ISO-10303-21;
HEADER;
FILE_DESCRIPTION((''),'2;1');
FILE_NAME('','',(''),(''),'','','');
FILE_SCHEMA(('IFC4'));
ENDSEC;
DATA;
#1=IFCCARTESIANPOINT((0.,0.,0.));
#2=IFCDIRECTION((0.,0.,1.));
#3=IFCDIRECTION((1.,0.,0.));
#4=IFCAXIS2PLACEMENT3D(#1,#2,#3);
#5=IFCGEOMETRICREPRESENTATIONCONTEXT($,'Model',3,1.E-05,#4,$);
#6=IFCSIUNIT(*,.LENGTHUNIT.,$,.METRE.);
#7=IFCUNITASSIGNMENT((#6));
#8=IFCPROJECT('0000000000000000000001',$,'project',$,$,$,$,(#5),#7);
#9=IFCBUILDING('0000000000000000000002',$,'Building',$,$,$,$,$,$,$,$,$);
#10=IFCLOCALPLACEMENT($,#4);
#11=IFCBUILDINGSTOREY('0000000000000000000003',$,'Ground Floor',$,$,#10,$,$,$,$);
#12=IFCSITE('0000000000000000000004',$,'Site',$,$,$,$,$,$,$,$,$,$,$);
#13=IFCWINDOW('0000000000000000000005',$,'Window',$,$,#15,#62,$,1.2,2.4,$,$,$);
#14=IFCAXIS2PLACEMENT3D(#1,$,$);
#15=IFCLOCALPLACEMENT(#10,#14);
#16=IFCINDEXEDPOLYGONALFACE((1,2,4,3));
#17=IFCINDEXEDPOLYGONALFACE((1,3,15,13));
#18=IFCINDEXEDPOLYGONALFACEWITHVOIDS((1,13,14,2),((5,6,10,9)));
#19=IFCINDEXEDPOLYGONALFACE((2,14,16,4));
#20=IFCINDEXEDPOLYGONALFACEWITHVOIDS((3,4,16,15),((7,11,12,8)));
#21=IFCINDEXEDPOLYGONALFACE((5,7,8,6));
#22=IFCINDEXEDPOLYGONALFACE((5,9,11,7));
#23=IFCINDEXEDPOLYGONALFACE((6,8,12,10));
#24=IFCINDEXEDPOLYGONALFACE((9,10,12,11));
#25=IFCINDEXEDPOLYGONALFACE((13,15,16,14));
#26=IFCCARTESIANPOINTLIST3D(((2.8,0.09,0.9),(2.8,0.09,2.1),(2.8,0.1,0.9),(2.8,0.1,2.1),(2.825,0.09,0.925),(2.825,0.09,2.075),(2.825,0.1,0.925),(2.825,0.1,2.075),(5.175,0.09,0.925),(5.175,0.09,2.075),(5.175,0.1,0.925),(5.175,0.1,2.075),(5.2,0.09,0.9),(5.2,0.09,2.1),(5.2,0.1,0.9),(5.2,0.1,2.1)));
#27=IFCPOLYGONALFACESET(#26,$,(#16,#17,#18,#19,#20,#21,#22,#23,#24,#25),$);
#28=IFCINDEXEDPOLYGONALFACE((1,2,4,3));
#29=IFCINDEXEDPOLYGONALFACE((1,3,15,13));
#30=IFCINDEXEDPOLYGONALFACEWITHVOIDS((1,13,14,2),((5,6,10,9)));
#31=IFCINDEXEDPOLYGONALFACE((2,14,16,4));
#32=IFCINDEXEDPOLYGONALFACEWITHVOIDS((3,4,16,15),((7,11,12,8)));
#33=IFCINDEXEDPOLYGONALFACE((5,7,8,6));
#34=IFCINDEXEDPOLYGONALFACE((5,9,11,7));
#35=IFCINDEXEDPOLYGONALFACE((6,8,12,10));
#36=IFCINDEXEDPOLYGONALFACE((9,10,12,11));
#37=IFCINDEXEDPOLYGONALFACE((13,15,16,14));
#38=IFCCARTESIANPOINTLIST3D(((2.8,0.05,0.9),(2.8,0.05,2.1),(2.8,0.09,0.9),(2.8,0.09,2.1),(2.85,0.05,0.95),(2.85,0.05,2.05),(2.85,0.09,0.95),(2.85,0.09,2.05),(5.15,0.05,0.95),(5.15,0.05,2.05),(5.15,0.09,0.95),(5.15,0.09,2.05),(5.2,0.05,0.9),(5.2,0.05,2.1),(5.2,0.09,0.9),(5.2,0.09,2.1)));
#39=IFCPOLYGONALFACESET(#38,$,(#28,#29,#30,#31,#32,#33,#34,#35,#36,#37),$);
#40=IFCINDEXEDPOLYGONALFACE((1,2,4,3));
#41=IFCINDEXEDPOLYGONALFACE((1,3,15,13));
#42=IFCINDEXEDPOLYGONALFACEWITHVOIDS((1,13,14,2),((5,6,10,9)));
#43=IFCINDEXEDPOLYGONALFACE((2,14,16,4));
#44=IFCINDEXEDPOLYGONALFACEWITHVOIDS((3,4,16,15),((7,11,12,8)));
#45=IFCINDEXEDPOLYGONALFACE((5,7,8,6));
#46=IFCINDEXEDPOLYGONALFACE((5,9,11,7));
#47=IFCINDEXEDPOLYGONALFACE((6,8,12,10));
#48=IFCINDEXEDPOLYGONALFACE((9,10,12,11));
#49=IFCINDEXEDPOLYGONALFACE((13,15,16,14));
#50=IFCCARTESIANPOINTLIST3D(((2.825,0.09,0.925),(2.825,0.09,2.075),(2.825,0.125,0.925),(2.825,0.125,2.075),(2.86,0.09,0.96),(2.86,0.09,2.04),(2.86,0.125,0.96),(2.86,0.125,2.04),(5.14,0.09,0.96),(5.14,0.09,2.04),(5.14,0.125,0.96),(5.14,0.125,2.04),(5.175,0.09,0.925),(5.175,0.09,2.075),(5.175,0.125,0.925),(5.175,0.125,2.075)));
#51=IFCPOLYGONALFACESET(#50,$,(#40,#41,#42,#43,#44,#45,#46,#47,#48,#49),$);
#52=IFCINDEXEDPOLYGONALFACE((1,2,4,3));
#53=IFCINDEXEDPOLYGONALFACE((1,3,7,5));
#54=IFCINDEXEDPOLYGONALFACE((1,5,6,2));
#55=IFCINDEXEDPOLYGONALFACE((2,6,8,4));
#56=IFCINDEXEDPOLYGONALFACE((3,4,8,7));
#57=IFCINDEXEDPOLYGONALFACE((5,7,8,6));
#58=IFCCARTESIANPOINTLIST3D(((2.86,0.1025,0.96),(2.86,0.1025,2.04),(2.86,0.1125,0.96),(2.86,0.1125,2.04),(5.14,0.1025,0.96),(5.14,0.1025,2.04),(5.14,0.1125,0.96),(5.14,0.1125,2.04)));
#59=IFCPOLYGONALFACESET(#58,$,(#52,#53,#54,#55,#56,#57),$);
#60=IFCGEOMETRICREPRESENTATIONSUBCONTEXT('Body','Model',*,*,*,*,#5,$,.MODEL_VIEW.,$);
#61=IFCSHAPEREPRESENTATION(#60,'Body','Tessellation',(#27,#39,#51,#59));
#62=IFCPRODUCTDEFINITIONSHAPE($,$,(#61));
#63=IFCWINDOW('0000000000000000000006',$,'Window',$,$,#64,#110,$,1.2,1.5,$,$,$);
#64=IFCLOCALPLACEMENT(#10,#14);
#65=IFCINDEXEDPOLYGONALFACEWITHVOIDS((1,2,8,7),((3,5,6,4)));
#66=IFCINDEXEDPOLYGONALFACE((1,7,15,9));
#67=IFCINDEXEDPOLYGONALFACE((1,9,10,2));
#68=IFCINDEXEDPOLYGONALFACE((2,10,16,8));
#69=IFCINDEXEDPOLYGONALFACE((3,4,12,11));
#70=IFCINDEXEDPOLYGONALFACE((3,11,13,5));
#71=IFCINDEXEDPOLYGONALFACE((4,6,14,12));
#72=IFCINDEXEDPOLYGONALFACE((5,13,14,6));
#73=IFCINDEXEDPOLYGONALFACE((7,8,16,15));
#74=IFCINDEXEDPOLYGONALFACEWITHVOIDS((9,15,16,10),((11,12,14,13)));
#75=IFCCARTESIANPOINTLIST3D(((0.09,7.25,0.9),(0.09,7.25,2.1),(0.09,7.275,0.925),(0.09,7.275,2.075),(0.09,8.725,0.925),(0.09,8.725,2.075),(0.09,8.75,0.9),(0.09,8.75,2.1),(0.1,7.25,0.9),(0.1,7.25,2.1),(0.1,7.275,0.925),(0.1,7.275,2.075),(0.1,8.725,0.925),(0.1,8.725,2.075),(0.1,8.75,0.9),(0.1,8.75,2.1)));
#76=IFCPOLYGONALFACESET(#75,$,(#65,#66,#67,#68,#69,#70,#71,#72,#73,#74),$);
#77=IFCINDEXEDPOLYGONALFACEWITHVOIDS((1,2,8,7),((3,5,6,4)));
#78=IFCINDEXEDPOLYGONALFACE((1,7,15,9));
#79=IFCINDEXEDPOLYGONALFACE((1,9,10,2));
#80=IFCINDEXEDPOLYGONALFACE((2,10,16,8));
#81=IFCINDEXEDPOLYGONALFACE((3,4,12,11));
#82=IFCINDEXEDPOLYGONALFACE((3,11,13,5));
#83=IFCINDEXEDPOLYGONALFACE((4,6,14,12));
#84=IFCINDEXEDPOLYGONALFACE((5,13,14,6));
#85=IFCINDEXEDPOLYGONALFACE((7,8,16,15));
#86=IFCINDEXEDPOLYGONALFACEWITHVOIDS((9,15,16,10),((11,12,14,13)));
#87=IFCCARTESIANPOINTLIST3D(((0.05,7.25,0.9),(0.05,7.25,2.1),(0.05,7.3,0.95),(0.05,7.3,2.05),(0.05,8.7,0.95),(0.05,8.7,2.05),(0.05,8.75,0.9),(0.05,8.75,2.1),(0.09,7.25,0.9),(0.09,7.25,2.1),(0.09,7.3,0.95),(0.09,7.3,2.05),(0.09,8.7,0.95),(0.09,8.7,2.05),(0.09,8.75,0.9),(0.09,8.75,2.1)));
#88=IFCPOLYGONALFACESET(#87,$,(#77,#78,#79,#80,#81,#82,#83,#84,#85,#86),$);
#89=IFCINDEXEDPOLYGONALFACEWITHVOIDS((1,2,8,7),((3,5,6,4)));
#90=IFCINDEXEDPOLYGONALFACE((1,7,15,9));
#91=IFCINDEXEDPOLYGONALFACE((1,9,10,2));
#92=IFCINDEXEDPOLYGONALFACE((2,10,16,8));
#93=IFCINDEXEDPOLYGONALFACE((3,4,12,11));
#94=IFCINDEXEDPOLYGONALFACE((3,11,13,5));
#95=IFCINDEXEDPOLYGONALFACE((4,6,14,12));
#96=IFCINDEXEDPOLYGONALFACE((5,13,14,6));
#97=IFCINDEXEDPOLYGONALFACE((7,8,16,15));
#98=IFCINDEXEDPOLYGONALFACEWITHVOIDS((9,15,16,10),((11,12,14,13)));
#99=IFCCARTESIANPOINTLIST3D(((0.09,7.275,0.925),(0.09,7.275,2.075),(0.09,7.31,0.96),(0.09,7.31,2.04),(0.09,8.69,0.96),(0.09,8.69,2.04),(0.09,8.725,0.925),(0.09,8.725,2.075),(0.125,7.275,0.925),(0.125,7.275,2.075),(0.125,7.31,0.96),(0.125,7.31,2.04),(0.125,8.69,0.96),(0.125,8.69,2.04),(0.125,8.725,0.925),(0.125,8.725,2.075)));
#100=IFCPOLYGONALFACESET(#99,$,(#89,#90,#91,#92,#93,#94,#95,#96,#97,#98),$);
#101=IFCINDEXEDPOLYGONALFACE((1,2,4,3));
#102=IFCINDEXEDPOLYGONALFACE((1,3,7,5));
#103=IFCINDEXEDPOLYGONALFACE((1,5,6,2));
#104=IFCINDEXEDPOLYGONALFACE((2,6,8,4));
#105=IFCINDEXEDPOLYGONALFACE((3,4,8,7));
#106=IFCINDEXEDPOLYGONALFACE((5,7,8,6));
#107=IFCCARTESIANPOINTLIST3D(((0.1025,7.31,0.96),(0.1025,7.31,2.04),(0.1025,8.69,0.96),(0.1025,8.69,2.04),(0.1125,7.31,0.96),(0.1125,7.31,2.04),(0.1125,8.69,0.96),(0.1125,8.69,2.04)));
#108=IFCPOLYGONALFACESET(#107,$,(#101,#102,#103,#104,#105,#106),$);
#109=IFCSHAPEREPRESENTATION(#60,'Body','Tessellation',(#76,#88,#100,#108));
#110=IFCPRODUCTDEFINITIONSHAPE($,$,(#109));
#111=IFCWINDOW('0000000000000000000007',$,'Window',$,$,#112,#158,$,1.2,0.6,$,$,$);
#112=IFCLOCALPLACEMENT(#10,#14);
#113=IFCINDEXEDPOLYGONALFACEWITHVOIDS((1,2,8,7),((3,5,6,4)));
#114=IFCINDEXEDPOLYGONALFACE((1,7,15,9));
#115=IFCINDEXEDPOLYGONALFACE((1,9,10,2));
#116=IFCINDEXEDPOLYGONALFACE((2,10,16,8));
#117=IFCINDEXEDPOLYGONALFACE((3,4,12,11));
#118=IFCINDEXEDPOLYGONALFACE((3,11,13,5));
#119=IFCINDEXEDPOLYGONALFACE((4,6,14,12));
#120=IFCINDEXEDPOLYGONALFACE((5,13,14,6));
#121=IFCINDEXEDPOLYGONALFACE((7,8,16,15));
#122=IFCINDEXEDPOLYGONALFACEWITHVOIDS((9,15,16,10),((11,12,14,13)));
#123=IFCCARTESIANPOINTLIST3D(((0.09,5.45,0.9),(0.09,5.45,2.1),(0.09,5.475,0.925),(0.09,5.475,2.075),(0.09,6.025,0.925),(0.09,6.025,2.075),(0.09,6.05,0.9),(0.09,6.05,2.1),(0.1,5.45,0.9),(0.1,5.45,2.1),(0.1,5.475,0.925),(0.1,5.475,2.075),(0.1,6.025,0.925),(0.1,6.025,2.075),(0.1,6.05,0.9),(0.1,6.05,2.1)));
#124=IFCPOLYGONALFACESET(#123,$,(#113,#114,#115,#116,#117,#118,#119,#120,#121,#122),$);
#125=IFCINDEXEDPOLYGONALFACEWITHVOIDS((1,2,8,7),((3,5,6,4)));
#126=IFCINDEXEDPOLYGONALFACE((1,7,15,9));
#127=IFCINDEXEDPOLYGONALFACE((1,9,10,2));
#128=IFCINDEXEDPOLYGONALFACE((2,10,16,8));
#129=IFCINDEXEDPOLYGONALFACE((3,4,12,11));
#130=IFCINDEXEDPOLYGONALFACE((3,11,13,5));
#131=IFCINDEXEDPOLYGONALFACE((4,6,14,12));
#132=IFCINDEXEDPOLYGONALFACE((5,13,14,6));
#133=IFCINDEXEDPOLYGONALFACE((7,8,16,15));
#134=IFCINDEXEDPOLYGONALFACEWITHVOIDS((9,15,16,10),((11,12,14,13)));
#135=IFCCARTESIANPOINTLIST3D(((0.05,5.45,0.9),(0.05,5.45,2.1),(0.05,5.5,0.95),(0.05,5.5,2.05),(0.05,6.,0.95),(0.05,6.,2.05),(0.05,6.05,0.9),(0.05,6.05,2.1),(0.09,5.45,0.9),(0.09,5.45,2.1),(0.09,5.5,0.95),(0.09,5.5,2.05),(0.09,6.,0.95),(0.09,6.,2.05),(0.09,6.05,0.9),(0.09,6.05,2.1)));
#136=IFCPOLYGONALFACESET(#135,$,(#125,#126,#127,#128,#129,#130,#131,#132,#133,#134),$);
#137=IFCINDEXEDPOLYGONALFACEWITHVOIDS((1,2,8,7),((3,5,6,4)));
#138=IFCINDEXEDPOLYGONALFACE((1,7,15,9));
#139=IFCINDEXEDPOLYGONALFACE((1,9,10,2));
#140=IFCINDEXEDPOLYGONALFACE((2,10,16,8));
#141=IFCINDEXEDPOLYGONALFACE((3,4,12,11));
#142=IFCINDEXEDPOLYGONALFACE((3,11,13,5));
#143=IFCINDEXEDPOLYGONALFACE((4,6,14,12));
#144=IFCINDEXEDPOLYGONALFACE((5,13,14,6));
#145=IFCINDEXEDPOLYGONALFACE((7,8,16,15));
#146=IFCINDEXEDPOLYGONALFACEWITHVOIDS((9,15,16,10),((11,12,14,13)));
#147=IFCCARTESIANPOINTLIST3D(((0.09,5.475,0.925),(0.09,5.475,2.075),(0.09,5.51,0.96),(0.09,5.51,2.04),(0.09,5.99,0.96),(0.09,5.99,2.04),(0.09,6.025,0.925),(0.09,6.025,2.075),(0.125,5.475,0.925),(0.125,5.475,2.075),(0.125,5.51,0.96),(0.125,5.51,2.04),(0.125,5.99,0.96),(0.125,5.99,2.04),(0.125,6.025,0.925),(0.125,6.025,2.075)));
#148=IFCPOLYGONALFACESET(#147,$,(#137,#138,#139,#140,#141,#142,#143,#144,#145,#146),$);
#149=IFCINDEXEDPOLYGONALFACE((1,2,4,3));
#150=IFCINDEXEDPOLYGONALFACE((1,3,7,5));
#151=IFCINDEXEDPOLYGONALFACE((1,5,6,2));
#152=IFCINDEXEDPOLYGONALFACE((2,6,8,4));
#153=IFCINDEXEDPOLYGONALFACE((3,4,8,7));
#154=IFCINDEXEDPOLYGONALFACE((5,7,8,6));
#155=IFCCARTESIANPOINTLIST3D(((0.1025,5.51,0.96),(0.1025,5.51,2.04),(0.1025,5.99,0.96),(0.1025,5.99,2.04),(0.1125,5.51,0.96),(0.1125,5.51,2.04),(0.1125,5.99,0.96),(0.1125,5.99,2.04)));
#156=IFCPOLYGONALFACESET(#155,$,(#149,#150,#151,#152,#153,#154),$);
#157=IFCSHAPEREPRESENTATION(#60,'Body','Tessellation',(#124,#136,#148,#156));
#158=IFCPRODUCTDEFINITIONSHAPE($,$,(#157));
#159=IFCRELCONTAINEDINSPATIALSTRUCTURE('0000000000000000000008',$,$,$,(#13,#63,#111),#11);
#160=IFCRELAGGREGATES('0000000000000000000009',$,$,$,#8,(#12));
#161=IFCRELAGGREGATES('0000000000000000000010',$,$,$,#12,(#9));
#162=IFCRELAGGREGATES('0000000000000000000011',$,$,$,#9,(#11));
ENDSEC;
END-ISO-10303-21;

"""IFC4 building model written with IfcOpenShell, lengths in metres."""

from ifc_helpers import new_model, si_unit, frame, origin_with_axes, place, context, subcontext, project, spatial, line, indexed_curve, outline, extrude, element, save


model = new_model("IFC4")

# Units and contexts
model_context = context("Model", 3, precision=1e-05, world=origin_with_axes())
body_context = subcontext(model_context, "Body", "Model", "MODEL_VIEW")
ifc_project = project(units=[si_unit("LENGTHUNIT", "METRE")], contexts=[model_context])

# Site, building, storey
site = spatial("IfcSite", under=ifc_project, Name="Site")
building = spatial("IfcBuilding", under=site, Name="Building")
storey_placement = place(None, origin_with_axes())
storey = spatial("IfcBuildingStorey", under=building, at=storey_placement, Name="Ground Floor")

# Windows
window_1_placement = place(storey_placement, frame((2.8, 0.0, 0.9), z_axis=(0.0, 0.0, 1.0), x_axis=(1.0, 0.0, 0.0)))
element("IfcWindow", 1, at=window_1_placement, inside=storey, Name="Window", OverallHeight=1.2, OverallWidth=2.4, context=body_context, shape_type="SweptSolid", body=[
    extrude(outline(indexed_curve([(0.0, 0.0), (2.4, 0.0), (2.4, 1.2), (0.0, 1.2)], segments=[line(1, 2, 3, 4, 1)]), holes=[indexed_curve([(0.025, 0.025), (2.375, 0.025), (2.375, 1.175), (0.025, 1.175)], segments=[line(1, 2, 3, 4, 1)])]), frame((0.0, 0.09, 0.0), z_axis=(0.0, -1.0, 0.0), x_axis=(1.0, 0.0, 0.0)), (0.0, 0.0, -1.0), 0.01),
    extrude(outline(indexed_curve([(0.0, 0.0), (2.4, 0.0), (2.4, 1.2), (0.0, 1.2)], segments=[line(1, 2, 3, 4, 1)]), holes=[indexed_curve([(0.05, 0.05), (2.35, 0.05), (2.35, 1.15), (0.05, 1.15)], segments=[line(1, 2, 3, 4, 1)])]), frame((0.0, 0.05, 0.0), z_axis=(0.0, -1.0, 0.0), x_axis=(1.0, 0.0, 0.0)), (0.0, 0.0, -1.0), 0.04),
    extrude(outline(indexed_curve([(0.0, 0.0), (2.35, 0.0), (2.35, 1.15), (0.0, 1.15)], segments=[line(1, 2, 3, 4, 1)]), holes=[indexed_curve([(0.035, 0.035), (2.315, 0.035), (2.315, 1.115), (0.035, 1.115)], segments=[line(1, 2, 3, 4, 1)])]), frame((0.025, 0.09, 0.025), z_axis=(0.0, -1.0, 0.0), x_axis=(1.0, 0.0, 0.0)), (0.0, 0.0, -1.0), 0.035),
    extrude(outline(indexed_curve([(0.035, 0.035), (2.315, 0.035), (2.315, 1.115), (0.035, 1.115)], segments=[line(1, 2, 3, 4, 1)])), frame((0.025, 0.1025, 0.025), z_axis=(0.0, -1.0, 0.0), x_axis=(1.0, 0.0, 0.0)), (0.0, 0.0, -1.0), 0.01),
])
window_2_placement = place(storey_placement, frame((0.0, 8.75, 0.9), z_axis=(0.0, 0.0, 1.0), x_axis=(0.0, -1.0, 0.0)))
element("IfcWindow", 2, at=window_2_placement, inside=storey, Name="Window", OverallHeight=1.2, OverallWidth=1.5, context=body_context, shape_type="SweptSolid", body=[
    extrude(outline(indexed_curve([(0.0, 0.0), (1.5, 0.0), (1.5, 1.2), (0.0, 1.2)], segments=[line(1, 2, 3, 4, 1)]), holes=[indexed_curve([(0.025, 0.025), (1.475, 0.025), (1.475, 1.175), (0.025, 1.175)], segments=[line(1, 2, 3, 4, 1)])]), frame((0.0, 0.09, 0.0), z_axis=(0.0, -1.0, 0.0), x_axis=(1.0, 0.0, 0.0)), (0.0, 0.0, -1.0), 0.01),
    extrude(outline(indexed_curve([(0.0, 0.0), (1.5, 0.0), (1.5, 1.2), (0.0, 1.2)], segments=[line(1, 2, 3, 4, 1)]), holes=[indexed_curve([(0.05, 0.05), (1.45, 0.05), (1.45, 1.15), (0.05, 1.15)], segments=[line(1, 2, 3, 4, 1)])]), frame((0.0, 0.05, 0.0), z_axis=(0.0, -1.0, 0.0), x_axis=(1.0, 0.0, 0.0)), (0.0, 0.0, -1.0), 0.04),
    extrude(outline(indexed_curve([(0.0, 0.0), (1.45, 0.0), (1.45, 1.15), (0.0, 1.15)], segments=[line(1, 2, 3, 4, 1)]), holes=[indexed_curve([(0.035, 0.035), (1.415, 0.035), (1.415, 1.115), (0.035, 1.115)], segments=[line(1, 2, 3, 4, 1)])]), frame((0.025, 0.09, 0.025), z_axis=(0.0, -1.0, 0.0), x_axis=(1.0, 0.0, 0.0)), (0.0, 0.0, -1.0), 0.035),
    extrude(outline(indexed_curve([(0.035, 0.035), (1.415, 0.035), (1.415, 1.115), (0.035, 1.115)], segments=[line(1, 2, 3, 4, 1)])), frame((0.025, 0.1025, 0.025), z_axis=(0.0, -1.0, 0.0), x_axis=(1.0, 0.0, 0.0)), (0.0, 0.0, -1.0), 0.01),
])
window_3_placement = place(storey_placement, frame((0.0, 6.05, 0.9), z_axis=(0.0, 0.0, 1.0), x_axis=(0.0, -1.0, 0.0)))
element("IfcWindow", 3, at=window_3_placement, inside=storey, Name="Window", OverallHeight=1.2, OverallWidth=0.6, context=body_context, shape_type="SweptSolid", body=[
    extrude(outline(indexed_curve([(0.0, 0.0), (0.6, 0.0), (0.6, 1.2), (0.0, 1.2)], segments=[line(1, 2, 3, 4, 1)]), holes=[indexed_curve([(0.025, 0.025), (0.575, 0.025), (0.575, 1.175), (0.025, 1.175)], segments=[line(1, 2, 3, 4, 1)])]), frame((0.0, 0.09, 0.0), z_axis=(0.0, -1.0, 0.0), x_axis=(1.0, 0.0, 0.0)), (0.0, 0.0, -1.0), 0.01),
    extrude(outline(indexed_curve([(0.0, 0.0), (0.6, 0.0), (0.6, 1.2), (0.0, 1.2)], segments=[line(1, 2, 3, 4, 1)]), holes=[indexed_curve([(0.05, 0.05), (0.55, 0.05), (0.55, 1.15), (0.05, 1.15)], segments=[line(1, 2, 3, 4, 1)])]), frame((0.0, 0.05, 0.0), z_axis=(0.0, -1.0, 0.0), x_axis=(1.0, 0.0, 0.0)), (0.0, 0.0, -1.0), 0.04),
    extrude(outline(indexed_curve([(0.0, 0.0), (0.55, 0.0), (0.55, 1.15), (0.0, 1.15)], segments=[line(1, 2, 3, 4, 1)]), holes=[indexed_curve([(0.035, 0.035), (0.515, 0.035), (0.515, 1.115), (0.035, 1.115)], segments=[line(1, 2, 3, 4, 1)])]), frame((0.025, 0.09, 0.025), z_axis=(0.0, -1.0, 0.0), x_axis=(1.0, 0.0, 0.0)), (0.0, 0.0, -1.0), 0.035),
    extrude(outline(indexed_curve([(0.035, 0.035), (0.515, 0.035), (0.515, 1.115), (0.035, 1.115)], segments=[line(1, 2, 3, 4, 1)])), frame((0.025, 0.1025, 0.025), z_axis=(0.0, -1.0, 0.0), x_axis=(1.0, 0.0, 0.0)), (0.0, 0.0, -1.0), 0.01),
])

save(model, "model.ifc")
